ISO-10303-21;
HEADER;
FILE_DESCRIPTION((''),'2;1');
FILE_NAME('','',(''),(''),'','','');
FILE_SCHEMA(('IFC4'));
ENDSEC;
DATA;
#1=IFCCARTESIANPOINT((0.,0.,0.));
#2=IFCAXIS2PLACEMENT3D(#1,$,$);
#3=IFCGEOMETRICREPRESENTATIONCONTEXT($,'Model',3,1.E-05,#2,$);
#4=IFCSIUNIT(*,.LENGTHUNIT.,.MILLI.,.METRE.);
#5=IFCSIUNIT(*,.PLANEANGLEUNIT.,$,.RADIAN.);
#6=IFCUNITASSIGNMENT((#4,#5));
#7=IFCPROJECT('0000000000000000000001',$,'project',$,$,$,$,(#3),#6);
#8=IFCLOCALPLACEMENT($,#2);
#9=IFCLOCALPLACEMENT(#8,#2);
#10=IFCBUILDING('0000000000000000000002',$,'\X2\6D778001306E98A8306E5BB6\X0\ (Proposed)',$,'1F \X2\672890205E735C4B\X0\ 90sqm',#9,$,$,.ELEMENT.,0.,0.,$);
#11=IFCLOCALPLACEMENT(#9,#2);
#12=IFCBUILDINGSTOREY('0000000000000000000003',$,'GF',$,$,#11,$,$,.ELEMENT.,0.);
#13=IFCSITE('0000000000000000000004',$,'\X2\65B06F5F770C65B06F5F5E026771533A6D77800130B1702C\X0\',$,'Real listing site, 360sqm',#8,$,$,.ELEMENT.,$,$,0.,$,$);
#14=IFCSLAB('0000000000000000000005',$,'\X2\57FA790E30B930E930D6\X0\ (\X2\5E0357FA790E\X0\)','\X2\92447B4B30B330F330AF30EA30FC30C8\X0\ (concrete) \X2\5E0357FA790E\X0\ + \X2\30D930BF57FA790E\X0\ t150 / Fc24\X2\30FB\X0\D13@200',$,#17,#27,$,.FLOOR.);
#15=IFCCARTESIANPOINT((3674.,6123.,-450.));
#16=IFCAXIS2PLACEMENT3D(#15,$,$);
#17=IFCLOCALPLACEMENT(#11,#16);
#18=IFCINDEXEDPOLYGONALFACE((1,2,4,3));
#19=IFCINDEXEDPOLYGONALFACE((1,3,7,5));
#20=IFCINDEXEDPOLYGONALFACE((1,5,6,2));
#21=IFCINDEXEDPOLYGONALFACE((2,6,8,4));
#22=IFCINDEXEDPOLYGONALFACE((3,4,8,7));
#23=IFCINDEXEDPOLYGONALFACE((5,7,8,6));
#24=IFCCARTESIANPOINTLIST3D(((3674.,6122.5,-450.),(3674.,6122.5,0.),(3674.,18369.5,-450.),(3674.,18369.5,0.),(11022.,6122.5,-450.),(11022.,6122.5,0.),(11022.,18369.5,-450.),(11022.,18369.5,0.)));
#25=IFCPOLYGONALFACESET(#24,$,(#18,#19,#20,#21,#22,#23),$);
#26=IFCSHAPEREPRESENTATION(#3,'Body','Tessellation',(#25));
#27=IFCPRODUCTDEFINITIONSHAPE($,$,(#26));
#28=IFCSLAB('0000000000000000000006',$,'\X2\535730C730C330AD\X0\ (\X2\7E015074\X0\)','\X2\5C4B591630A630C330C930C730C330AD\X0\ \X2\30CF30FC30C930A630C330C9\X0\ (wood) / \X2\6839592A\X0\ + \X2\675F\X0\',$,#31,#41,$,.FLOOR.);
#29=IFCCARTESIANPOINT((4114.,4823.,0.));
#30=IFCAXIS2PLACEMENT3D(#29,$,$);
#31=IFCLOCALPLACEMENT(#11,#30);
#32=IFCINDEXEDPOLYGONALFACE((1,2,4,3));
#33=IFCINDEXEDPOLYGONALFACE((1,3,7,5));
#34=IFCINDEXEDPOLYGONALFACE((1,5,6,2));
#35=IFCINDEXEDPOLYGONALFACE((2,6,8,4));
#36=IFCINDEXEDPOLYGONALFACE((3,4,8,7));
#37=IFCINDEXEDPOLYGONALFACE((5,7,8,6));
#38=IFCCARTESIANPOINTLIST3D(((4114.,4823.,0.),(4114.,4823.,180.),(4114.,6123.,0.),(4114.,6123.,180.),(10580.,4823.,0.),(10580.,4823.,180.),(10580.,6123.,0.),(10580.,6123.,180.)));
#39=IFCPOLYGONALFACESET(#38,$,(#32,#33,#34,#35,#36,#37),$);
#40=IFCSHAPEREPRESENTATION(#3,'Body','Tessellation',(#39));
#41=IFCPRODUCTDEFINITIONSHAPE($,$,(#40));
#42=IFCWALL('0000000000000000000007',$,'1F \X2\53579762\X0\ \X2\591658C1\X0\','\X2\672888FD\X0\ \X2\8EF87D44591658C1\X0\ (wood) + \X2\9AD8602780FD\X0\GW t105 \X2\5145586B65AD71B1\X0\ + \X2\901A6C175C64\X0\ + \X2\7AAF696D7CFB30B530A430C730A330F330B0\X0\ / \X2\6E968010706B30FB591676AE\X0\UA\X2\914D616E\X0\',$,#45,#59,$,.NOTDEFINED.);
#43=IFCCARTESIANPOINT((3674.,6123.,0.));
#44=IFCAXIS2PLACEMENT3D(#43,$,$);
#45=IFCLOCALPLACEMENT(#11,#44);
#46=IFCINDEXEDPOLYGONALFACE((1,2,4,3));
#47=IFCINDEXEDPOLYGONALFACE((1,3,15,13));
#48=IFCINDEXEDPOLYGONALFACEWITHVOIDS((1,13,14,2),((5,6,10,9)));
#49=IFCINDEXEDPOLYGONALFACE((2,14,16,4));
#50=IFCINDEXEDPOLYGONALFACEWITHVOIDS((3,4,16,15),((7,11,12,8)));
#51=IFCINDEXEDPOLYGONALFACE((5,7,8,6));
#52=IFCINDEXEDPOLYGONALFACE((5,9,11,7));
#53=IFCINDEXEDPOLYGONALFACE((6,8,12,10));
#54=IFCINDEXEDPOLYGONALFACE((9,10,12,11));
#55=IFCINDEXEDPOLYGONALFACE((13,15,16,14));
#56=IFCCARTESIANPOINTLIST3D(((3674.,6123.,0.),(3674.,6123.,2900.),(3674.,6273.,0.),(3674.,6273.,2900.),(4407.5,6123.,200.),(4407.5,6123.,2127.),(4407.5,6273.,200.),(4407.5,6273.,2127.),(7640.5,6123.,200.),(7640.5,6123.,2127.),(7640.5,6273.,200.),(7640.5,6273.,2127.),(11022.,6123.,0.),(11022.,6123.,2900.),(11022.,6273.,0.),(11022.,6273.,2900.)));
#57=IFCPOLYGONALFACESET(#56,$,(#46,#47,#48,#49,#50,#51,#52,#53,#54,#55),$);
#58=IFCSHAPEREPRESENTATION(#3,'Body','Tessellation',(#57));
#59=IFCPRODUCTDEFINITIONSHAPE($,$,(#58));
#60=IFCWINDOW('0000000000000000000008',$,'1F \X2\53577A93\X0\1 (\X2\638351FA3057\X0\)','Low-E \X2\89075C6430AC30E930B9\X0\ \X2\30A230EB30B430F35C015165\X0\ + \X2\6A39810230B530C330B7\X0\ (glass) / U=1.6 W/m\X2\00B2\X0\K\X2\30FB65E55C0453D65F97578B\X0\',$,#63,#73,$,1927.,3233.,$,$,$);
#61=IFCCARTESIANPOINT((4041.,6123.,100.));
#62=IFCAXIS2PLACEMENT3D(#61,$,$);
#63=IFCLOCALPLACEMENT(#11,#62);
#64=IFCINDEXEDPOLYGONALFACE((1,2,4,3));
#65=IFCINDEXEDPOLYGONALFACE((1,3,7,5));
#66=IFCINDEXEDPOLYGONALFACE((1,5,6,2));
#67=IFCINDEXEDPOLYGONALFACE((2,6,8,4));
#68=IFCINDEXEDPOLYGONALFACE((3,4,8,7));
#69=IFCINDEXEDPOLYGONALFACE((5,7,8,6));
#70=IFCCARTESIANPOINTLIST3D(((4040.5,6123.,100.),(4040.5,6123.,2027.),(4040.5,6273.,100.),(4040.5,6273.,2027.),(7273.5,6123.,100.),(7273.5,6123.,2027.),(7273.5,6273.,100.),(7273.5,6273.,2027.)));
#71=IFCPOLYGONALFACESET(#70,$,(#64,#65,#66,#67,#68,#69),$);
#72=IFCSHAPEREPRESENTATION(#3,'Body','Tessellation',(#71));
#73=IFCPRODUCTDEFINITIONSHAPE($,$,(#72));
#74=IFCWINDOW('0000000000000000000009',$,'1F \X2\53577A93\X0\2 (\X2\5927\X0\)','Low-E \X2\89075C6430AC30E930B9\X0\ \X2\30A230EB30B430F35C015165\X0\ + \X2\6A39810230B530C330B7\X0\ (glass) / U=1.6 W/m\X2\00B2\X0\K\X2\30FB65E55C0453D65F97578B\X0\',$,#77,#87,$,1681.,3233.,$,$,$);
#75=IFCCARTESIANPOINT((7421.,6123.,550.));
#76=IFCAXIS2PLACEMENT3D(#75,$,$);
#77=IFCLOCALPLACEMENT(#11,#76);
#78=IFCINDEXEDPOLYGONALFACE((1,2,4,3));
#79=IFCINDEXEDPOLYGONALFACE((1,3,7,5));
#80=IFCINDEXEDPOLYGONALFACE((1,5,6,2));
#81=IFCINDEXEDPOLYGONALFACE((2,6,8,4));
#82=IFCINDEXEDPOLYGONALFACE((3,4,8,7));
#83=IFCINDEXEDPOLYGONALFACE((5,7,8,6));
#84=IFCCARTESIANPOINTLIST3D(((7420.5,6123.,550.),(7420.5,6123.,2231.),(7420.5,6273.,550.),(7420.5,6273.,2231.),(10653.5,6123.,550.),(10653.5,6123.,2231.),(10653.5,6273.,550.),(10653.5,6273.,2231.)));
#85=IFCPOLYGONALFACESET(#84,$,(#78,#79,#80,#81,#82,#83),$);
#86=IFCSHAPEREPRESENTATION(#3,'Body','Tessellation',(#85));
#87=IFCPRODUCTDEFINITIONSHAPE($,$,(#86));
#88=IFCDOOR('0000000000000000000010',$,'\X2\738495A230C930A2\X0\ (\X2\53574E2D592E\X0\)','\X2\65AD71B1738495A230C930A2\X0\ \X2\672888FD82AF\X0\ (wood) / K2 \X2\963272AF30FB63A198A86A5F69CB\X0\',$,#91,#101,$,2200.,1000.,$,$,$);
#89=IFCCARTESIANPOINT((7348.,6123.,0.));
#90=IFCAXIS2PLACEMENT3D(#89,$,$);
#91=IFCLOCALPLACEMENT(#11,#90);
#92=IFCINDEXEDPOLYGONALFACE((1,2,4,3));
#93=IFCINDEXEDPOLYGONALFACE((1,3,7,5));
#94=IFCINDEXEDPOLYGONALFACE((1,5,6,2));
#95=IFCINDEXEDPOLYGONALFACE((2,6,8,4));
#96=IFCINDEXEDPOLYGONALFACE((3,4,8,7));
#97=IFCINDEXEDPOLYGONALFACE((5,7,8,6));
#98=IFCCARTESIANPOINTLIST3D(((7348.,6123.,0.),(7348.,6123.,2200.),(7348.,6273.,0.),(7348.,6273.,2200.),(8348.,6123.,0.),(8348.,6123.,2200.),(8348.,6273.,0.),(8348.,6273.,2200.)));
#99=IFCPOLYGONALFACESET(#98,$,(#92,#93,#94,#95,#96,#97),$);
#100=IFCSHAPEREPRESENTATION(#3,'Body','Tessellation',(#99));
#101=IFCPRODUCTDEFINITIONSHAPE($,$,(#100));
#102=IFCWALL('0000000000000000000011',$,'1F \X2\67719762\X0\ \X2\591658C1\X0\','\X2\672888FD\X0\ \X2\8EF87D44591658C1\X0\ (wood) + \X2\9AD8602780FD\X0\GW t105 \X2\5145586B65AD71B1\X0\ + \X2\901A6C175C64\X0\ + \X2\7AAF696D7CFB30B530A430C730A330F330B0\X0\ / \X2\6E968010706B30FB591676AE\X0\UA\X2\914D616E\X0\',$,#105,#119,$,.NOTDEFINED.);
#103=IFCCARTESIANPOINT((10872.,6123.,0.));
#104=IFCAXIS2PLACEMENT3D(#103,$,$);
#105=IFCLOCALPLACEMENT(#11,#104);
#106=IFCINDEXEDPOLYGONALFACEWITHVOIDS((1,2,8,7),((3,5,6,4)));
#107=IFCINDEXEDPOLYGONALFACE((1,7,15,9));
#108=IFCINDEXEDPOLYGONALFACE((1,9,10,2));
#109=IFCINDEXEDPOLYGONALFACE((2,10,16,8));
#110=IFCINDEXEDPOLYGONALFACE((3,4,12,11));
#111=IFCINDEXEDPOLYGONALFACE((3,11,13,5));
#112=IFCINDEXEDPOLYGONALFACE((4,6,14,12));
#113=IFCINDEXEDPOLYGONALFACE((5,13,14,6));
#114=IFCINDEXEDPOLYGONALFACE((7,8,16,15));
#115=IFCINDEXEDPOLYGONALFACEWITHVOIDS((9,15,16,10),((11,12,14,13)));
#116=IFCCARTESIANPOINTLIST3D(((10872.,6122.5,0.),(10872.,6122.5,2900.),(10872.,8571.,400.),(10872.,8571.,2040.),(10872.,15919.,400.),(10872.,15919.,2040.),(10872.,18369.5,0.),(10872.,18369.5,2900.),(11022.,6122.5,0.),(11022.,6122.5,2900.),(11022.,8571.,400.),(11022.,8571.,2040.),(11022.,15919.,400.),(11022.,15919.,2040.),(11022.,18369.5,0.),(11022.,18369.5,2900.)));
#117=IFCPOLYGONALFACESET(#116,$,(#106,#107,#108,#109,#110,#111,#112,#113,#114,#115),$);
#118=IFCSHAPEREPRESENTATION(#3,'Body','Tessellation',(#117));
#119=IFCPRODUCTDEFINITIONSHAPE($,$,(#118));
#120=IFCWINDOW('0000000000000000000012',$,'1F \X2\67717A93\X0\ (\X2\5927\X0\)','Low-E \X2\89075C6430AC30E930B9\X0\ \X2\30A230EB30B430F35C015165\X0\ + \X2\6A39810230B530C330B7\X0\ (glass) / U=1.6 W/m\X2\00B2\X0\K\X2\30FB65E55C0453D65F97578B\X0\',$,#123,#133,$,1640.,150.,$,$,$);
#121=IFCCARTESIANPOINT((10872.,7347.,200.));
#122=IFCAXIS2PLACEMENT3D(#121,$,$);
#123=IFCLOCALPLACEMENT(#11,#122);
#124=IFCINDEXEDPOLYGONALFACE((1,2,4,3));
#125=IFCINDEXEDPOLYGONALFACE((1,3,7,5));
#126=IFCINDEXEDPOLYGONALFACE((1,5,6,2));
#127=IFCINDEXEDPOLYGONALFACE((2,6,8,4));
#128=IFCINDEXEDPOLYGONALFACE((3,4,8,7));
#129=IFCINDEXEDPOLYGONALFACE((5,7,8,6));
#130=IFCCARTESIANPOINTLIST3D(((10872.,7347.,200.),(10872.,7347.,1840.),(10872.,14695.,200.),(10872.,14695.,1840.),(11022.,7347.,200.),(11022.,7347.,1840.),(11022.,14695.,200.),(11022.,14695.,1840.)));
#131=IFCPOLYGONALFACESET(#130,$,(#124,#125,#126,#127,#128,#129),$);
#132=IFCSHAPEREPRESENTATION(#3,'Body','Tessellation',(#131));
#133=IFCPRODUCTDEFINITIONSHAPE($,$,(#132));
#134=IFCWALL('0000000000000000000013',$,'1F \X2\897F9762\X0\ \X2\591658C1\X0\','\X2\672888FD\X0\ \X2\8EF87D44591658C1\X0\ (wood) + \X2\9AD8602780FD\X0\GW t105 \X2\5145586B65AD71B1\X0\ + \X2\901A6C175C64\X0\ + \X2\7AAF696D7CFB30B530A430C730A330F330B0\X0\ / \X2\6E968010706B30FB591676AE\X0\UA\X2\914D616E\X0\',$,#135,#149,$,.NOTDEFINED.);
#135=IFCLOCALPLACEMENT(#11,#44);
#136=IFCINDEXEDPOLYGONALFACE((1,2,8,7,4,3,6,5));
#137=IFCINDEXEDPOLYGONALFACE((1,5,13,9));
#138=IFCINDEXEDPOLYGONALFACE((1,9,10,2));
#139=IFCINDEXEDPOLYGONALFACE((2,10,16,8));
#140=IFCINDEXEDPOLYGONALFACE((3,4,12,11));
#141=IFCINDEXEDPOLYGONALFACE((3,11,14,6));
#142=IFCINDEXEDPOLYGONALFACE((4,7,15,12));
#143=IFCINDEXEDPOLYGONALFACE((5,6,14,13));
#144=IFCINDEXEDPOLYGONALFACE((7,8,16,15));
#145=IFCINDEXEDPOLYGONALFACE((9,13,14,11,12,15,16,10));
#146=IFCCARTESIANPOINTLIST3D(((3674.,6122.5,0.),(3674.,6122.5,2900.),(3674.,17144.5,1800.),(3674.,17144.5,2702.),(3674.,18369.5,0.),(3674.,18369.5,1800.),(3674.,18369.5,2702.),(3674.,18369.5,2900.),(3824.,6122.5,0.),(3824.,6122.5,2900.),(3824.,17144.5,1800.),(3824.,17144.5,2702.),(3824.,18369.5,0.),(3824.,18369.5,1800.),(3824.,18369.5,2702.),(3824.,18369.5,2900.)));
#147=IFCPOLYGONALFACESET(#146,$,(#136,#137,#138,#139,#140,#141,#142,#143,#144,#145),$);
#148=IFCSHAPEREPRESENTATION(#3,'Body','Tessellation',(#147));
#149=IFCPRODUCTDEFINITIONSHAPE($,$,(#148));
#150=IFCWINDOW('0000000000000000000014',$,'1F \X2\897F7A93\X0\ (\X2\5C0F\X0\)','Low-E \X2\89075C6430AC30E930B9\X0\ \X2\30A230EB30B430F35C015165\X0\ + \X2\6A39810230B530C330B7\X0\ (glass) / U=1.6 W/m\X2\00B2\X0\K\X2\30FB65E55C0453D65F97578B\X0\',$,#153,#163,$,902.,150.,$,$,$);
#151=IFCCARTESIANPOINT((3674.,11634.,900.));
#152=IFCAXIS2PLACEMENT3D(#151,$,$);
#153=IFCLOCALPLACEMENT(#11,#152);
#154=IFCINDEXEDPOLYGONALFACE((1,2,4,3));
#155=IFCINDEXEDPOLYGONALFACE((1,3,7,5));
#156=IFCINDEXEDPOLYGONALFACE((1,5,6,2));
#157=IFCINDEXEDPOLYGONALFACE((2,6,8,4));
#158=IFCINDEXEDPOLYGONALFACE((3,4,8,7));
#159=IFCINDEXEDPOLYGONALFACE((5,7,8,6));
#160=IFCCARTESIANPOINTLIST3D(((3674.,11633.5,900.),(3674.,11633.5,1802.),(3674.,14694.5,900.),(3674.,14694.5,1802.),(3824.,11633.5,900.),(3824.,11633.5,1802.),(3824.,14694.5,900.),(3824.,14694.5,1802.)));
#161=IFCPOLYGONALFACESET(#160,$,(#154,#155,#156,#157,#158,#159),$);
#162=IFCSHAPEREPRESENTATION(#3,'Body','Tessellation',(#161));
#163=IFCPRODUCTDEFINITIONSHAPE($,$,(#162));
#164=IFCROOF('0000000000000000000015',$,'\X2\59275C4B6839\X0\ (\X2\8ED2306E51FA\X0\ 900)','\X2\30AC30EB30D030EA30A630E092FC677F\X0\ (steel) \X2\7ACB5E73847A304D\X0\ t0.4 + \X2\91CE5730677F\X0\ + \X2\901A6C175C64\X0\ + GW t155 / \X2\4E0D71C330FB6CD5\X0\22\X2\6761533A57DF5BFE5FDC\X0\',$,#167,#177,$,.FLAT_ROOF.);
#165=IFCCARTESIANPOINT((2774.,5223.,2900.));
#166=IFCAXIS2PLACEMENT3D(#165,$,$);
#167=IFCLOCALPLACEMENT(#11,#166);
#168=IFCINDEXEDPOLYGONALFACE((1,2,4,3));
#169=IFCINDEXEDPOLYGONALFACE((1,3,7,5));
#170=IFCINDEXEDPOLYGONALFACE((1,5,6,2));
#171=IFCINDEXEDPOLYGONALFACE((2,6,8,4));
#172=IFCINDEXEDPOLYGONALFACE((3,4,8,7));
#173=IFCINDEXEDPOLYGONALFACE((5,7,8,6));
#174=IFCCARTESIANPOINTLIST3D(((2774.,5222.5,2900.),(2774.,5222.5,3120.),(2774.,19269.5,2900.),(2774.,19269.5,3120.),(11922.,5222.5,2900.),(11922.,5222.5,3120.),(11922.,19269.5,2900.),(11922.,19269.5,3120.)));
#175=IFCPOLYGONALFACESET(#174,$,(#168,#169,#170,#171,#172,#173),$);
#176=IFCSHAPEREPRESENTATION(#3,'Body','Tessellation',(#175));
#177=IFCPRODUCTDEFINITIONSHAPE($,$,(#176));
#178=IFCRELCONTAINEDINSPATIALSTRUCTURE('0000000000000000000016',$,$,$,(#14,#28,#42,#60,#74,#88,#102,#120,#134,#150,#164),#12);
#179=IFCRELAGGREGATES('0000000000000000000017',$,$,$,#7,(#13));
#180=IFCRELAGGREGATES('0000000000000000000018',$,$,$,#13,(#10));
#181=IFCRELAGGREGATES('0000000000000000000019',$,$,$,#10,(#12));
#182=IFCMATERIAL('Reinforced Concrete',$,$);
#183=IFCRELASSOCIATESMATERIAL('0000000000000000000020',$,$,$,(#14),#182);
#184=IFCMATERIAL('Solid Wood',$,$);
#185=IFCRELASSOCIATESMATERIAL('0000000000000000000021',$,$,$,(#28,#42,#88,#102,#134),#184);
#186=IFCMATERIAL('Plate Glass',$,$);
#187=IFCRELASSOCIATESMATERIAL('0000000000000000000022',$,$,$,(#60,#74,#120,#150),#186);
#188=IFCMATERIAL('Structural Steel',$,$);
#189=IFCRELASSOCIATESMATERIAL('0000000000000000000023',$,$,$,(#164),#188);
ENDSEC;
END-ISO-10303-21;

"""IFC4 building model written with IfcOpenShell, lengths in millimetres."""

from ifc_helpers import new_model, si_unit, frame, frame_2d, origin, place, context, project, spatial, rectangle, extrude, material, element, fill, save


model = new_model("IFC4")

# Units and contexts
model_context = context("Model", 3, precision=1e-05, world=origin())
ifc_project = project(units=[si_unit("LENGTHUNIT", "METRE", prefix="MILLI"), si_unit("PLANEANGLEUNIT", "RADIAN")], contexts=[model_context])

# Site, building, storey
site_placement = place(None, origin())
site = spatial("IfcSite", under=ifc_project, at=site_placement, Name="新潟県新潟市東区海老ケ瀬", ObjectType="Real listing site, 360sqm", CompositionType="ELEMENT", RefElevation=0.0)
building_placement = place(site_placement, origin())
building = spatial("IfcBuilding", under=site, at=building_placement, Name="海老の風の家 (Proposed)", ObjectType="1F 木造平屋 90sqm", CompositionType="ELEMENT", ElevationOfRefHeight=0.0, ElevationOfTerrain=0.0)
storey_placement = place(building_placement, origin())
storey = spatial("IfcBuildingStorey", under=building, at=storey_placement, Name="GF", CompositionType="ELEMENT", Elevation=0.0)

# Slabs
ifc_material_1 = material(Name="Reinforced Concrete")
slab_1_placement = place(storey_placement, frame((3674.0, 6123.0, -450.0)))
element("IfcSlab", 1, at=slab_1_placement, inside=storey, material=ifc_material_1, Name="基礎スラブ (布基礎)", Description="鉄筋コンクリート (concrete) 布基礎 + ベタ基礎 t150 / Fc24・D13@200", PredefinedType="FLOOR", context=model_context, shape_type="SweptSolid", body=[
    extrude(rectangle(XDim=7348.0, YDim=12247.0, at=frame_2d((3674.0, 6123.0))), frame((3674.0, 6123.0, -450.0)), (0.0, 0.0, 1.0), 450.0),
])
ifc_material_2 = material(Name="Solid Wood")
slab_2_placement = place(storey_placement, frame((4114.0, 4823.0, 0.0)))
element("IfcSlab", 2, at=slab_2_placement, inside=storey, material=ifc_material_2, Name="南デッキ (縁側)", Description="屋外ウッドデッキ ハードウッド (wood) / 根太 + 束", PredefinedType="FLOOR", context=model_context, shape_type="SweptSolid", body=[
    extrude(rectangle(XDim=6466.0, YDim=1300.0, at=frame_2d((3233.0, 650.0))), frame((4114.0, 4823.0, 0.0)), (0.0, 0.0, 1.0), 180.0),
])

# Wall, openings, windows, door
wall_1_placement = place(storey_placement, frame((3674.0, 6123.0, 0.0)))
wall_1 = element("IfcWall", 3, at=wall_1_placement, inside=storey, material=ifc_material_2, Name="1F 南面 外壁", Description="木製 軸組外壁 (wood) + 高性能GW t105 充填断熱 + 通気層 + 窯業系サイディング / 準耐火・外皮UA配慮", PredefinedType="NOTDEFINED", context=model_context, shape_type="SweptSolid", body=[
    extrude(rectangle(XDim=7348.0, YDim=150.0, at=frame_2d((3674.0, 75.0))), frame((3674.0, 6123.0, 0.0)), (0.0, 0.0, 1.0), 2900.0),
])
opening_1_placement = place(storey_placement, frame((4041.0, 6123.0, 100.0)))
opening_1 = element("IfcOpeningElement", 4, at=opening_1_placement, cuts=wall_1, PredefinedType="NOTDEFINED", context=model_context, shape_type="SweptSolid", body=[
    extrude(rectangle(XDim=3233.0, YDim=150.0, at=frame_2d((1616.0, 75.0))), frame((4041.0, 6123.0, 100.0)), (0.0, 0.0, 1.0), 1927.0),
])
opening_2_placement = place(storey_placement, frame((7421.0, 6123.0, 550.0)))
opening_2 = element("IfcOpeningElement", 5, at=opening_2_placement, cuts=wall_1, PredefinedType="NOTDEFINED", context=model_context, shape_type="SweptSolid", body=[
    extrude(rectangle(XDim=3233.0, YDim=150.0, at=frame_2d((1616.0, 75.0))), frame((7421.0, 6123.0, 550.0)), (0.0, 0.0, 1.0), 1681.0),
])
opening_3_placement = place(storey_placement, frame((7348.0, 6123.0, 0.0)))
opening_3 = element("IfcOpeningElement", 6, at=opening_3_placement, cuts=wall_1, PredefinedType="NOTDEFINED", context=model_context, shape_type="SweptSolid", body=[
    extrude(rectangle(XDim=1000.0, YDim=150.0, at=frame_2d((500.0, 75.0))), frame((7348.0, 6123.0, 0.0)), (0.0, 0.0, 1.0), 2200.0),
])
ifc_material_3 = material(Name="Plate Glass")
window_1_placement = place(storey_placement, frame((4041.0, 6123.0, 100.0)))
window_1 = element("IfcWindow", 7, at=window_1_placement, inside=storey, material=ifc_material_3, Name="1F 南窓1 (掃出し)", Description="Low-E 複層ガラス アルゴン封入 + 樹脂サッシ (glass) / U=1.6 W/m²K・日射取得型", OverallHeight=1927.0, OverallWidth=3233.0, context=model_context, shape_type="SweptSolid", body=[
    extrude(rectangle(XDim=3233.0, YDim=150.0, at=frame_2d((1616.0, 75.0))), frame((4041.0, 6123.0, 100.0)), (0.0, 0.0, 1.0), 1927.0),
])
fill(opening_1, window_1)
window_2_placement = place(storey_placement, frame((7421.0, 6123.0, 550.0)))
window_2 = element("IfcWindow", 8, at=window_2_placement, inside=storey, material=ifc_material_3, Name="1F 南窓2 (大)", Description="Low-E 複層ガラス アルゴン封入 + 樹脂サッシ (glass) / U=1.6 W/m²K・日射取得型", OverallHeight=1681.0, OverallWidth=3233.0, context=model_context, shape_type="SweptSolid", body=[
    extrude(rectangle(XDim=3233.0, YDim=150.0, at=frame_2d((1616.0, 75.0))), frame((7421.0, 6123.0, 550.0)), (0.0, 0.0, 1.0), 1681.0),
])
fill(opening_2, window_2)
door_placement = place(storey_placement, frame((7348.0, 6123.0, 0.0)))
door = element("IfcDoor", 9, at=door_placement, inside=storey, material=ifc_material_2, Name="玄関ドア (南中央)", Description="断熱玄関ドア 木製芯 (wood) / K2 防犯・採風機構", OverallHeight=2200.0, OverallWidth=1000.0, context=model_context, shape_type="SweptSolid", body=[
    extrude(rectangle(XDim=1000.0, YDim=150.0, at=frame_2d((500.0, 75.0))), frame((7348.0, 6123.0, 0.0)), (0.0, 0.0, 1.0), 2200.0),
])
fill(opening_3, door)

# Walls, openings, windows
wall_2_placement = place(storey_placement, frame((10872.0, 6123.0, 0.0)))
wall_2 = element("IfcWall", 10, at=wall_2_placement, inside=storey, material=ifc_material_2, Name="1F 東面 外壁", Description="木製 軸組外壁 (wood) + 高性能GW t105 充填断熱 + 通気層 + 窯業系サイディング / 準耐火・外皮UA配慮", PredefinedType="NOTDEFINED", context=model_context, shape_type="SweptSolid", body=[
    extrude(rectangle(XDim=150.0, YDim=12247.0, at=frame_2d((75.0, 6123.0))), frame((10872.0, 6123.0, 0.0)), (0.0, 0.0, 1.0), 2900.0),
])
opening_4_placement = place(storey_placement, frame((10872.0, 7347.0, 200.0)))
opening_4 = element("IfcOpeningElement", 11, at=opening_4_placement, cuts=wall_2, PredefinedType="NOTDEFINED", context=model_context, shape_type="SweptSolid", body=[
    extrude(rectangle(XDim=150.0, YDim=7348.0, at=frame_2d((75.0, 3674.0))), frame((10872.0, 7347.0, 200.0)), (0.0, 0.0, 1.0), 1640.0),
])
window_3_placement = place(storey_placement, frame((10872.0, 7347.0, 200.0)))
window_3 = element("IfcWindow", 12, at=window_3_placement, inside=storey, material=ifc_material_3, Name="1F 東窓 (大)", Description="Low-E 複層ガラス アルゴン封入 + 樹脂サッシ (glass) / U=1.6 W/m²K・日射取得型", OverallHeight=1640.0, OverallWidth=150.0, context=model_context, shape_type="SweptSolid", body=[
    extrude(rectangle(XDim=150.0, YDim=7348.0, at=frame_2d((75.0, 3674.0))), frame((10872.0, 7347.0, 200.0)), (0.0, 0.0, 1.0), 1640.0),
])
fill(opening_4, window_3)
wall_3_placement = place(storey_placement, frame((3674.0, 6123.0, 0.0)))
wall_3 = element("IfcWall", 13, at=wall_3_placement, inside=storey, material=ifc_material_2, Name="1F 西面 外壁", Description="木製 軸組外壁 (wood) + 高性能GW t105 充填断熱 + 通気層 + 窯業系サイディング / 準耐火・外皮UA配慮", PredefinedType="NOTDEFINED", context=model_context, shape_type="SweptSolid", body=[
    extrude(rectangle(XDim=150.0, YDim=12247.0, at=frame_2d((75.0, 6123.0))), frame((3674.0, 6123.0, 0.0)), (0.0, 0.0, 1.0), 2900.0),
])
opening_5_placement = place(storey_placement, frame((3674.0, 11634.0, 900.0)))
opening_5 = element("IfcOpeningElement", 14, at=opening_5_placement, cuts=wall_3, PredefinedType="NOTDEFINED", context=model_context, shape_type="SweptSolid", body=[
    extrude(rectangle(XDim=150.0, YDim=3061.0, at=frame_2d((75.0, 1530.0))), frame((3674.0, 11634.0, 900.0)), (0.0, 0.0, 1.0), 902.0),
])
window_4_placement = place(storey_placement, frame((3674.0, 11634.0, 900.0)))
window_4 = element("IfcWindow", 15, at=window_4_placement, inside=storey, material=ifc_material_3, Name="1F 西窓 (小)", Description="Low-E 複層ガラス アルゴン封入 + 樹脂サッシ (glass) / U=1.6 W/m²K・日射取得型", OverallHeight=902.0, OverallWidth=150.0, context=model_context, shape_type="SweptSolid", body=[
    extrude(rectangle(XDim=150.0, YDim=3061.0, at=frame_2d((75.0, 1530.0))), frame((3674.0, 11634.0, 900.0)), (0.0, 0.0, 1.0), 902.0),
])
fill(opening_5, window_4)

# Roof
ifc_material_4 = material(Name="Structural Steel")
roof_placement = place(storey_placement, frame((2774.0, 5223.0, 2900.0)))
element("IfcRoof", 16, at=roof_placement, inside=storey, material=ifc_material_4, Name="大屋根 (軒の出 900)", Description="ガルバリウム鋼板 (steel) 立平葺き t0.4 + 野地板 + 通気層 + GW t155 / 不燃・法22条区域対応", PredefinedType="FLAT_ROOF", context=model_context, shape_type="SweptSolid", body=[
    extrude(rectangle(XDim=9148.0, YDim=14047.0, at=frame_2d((4574.0, 7023.0))), frame((2774.0, 5223.0, 2900.0)), (0.0, 0.0, 1.0), 220.0),
])

save(model, "model.ifc")
